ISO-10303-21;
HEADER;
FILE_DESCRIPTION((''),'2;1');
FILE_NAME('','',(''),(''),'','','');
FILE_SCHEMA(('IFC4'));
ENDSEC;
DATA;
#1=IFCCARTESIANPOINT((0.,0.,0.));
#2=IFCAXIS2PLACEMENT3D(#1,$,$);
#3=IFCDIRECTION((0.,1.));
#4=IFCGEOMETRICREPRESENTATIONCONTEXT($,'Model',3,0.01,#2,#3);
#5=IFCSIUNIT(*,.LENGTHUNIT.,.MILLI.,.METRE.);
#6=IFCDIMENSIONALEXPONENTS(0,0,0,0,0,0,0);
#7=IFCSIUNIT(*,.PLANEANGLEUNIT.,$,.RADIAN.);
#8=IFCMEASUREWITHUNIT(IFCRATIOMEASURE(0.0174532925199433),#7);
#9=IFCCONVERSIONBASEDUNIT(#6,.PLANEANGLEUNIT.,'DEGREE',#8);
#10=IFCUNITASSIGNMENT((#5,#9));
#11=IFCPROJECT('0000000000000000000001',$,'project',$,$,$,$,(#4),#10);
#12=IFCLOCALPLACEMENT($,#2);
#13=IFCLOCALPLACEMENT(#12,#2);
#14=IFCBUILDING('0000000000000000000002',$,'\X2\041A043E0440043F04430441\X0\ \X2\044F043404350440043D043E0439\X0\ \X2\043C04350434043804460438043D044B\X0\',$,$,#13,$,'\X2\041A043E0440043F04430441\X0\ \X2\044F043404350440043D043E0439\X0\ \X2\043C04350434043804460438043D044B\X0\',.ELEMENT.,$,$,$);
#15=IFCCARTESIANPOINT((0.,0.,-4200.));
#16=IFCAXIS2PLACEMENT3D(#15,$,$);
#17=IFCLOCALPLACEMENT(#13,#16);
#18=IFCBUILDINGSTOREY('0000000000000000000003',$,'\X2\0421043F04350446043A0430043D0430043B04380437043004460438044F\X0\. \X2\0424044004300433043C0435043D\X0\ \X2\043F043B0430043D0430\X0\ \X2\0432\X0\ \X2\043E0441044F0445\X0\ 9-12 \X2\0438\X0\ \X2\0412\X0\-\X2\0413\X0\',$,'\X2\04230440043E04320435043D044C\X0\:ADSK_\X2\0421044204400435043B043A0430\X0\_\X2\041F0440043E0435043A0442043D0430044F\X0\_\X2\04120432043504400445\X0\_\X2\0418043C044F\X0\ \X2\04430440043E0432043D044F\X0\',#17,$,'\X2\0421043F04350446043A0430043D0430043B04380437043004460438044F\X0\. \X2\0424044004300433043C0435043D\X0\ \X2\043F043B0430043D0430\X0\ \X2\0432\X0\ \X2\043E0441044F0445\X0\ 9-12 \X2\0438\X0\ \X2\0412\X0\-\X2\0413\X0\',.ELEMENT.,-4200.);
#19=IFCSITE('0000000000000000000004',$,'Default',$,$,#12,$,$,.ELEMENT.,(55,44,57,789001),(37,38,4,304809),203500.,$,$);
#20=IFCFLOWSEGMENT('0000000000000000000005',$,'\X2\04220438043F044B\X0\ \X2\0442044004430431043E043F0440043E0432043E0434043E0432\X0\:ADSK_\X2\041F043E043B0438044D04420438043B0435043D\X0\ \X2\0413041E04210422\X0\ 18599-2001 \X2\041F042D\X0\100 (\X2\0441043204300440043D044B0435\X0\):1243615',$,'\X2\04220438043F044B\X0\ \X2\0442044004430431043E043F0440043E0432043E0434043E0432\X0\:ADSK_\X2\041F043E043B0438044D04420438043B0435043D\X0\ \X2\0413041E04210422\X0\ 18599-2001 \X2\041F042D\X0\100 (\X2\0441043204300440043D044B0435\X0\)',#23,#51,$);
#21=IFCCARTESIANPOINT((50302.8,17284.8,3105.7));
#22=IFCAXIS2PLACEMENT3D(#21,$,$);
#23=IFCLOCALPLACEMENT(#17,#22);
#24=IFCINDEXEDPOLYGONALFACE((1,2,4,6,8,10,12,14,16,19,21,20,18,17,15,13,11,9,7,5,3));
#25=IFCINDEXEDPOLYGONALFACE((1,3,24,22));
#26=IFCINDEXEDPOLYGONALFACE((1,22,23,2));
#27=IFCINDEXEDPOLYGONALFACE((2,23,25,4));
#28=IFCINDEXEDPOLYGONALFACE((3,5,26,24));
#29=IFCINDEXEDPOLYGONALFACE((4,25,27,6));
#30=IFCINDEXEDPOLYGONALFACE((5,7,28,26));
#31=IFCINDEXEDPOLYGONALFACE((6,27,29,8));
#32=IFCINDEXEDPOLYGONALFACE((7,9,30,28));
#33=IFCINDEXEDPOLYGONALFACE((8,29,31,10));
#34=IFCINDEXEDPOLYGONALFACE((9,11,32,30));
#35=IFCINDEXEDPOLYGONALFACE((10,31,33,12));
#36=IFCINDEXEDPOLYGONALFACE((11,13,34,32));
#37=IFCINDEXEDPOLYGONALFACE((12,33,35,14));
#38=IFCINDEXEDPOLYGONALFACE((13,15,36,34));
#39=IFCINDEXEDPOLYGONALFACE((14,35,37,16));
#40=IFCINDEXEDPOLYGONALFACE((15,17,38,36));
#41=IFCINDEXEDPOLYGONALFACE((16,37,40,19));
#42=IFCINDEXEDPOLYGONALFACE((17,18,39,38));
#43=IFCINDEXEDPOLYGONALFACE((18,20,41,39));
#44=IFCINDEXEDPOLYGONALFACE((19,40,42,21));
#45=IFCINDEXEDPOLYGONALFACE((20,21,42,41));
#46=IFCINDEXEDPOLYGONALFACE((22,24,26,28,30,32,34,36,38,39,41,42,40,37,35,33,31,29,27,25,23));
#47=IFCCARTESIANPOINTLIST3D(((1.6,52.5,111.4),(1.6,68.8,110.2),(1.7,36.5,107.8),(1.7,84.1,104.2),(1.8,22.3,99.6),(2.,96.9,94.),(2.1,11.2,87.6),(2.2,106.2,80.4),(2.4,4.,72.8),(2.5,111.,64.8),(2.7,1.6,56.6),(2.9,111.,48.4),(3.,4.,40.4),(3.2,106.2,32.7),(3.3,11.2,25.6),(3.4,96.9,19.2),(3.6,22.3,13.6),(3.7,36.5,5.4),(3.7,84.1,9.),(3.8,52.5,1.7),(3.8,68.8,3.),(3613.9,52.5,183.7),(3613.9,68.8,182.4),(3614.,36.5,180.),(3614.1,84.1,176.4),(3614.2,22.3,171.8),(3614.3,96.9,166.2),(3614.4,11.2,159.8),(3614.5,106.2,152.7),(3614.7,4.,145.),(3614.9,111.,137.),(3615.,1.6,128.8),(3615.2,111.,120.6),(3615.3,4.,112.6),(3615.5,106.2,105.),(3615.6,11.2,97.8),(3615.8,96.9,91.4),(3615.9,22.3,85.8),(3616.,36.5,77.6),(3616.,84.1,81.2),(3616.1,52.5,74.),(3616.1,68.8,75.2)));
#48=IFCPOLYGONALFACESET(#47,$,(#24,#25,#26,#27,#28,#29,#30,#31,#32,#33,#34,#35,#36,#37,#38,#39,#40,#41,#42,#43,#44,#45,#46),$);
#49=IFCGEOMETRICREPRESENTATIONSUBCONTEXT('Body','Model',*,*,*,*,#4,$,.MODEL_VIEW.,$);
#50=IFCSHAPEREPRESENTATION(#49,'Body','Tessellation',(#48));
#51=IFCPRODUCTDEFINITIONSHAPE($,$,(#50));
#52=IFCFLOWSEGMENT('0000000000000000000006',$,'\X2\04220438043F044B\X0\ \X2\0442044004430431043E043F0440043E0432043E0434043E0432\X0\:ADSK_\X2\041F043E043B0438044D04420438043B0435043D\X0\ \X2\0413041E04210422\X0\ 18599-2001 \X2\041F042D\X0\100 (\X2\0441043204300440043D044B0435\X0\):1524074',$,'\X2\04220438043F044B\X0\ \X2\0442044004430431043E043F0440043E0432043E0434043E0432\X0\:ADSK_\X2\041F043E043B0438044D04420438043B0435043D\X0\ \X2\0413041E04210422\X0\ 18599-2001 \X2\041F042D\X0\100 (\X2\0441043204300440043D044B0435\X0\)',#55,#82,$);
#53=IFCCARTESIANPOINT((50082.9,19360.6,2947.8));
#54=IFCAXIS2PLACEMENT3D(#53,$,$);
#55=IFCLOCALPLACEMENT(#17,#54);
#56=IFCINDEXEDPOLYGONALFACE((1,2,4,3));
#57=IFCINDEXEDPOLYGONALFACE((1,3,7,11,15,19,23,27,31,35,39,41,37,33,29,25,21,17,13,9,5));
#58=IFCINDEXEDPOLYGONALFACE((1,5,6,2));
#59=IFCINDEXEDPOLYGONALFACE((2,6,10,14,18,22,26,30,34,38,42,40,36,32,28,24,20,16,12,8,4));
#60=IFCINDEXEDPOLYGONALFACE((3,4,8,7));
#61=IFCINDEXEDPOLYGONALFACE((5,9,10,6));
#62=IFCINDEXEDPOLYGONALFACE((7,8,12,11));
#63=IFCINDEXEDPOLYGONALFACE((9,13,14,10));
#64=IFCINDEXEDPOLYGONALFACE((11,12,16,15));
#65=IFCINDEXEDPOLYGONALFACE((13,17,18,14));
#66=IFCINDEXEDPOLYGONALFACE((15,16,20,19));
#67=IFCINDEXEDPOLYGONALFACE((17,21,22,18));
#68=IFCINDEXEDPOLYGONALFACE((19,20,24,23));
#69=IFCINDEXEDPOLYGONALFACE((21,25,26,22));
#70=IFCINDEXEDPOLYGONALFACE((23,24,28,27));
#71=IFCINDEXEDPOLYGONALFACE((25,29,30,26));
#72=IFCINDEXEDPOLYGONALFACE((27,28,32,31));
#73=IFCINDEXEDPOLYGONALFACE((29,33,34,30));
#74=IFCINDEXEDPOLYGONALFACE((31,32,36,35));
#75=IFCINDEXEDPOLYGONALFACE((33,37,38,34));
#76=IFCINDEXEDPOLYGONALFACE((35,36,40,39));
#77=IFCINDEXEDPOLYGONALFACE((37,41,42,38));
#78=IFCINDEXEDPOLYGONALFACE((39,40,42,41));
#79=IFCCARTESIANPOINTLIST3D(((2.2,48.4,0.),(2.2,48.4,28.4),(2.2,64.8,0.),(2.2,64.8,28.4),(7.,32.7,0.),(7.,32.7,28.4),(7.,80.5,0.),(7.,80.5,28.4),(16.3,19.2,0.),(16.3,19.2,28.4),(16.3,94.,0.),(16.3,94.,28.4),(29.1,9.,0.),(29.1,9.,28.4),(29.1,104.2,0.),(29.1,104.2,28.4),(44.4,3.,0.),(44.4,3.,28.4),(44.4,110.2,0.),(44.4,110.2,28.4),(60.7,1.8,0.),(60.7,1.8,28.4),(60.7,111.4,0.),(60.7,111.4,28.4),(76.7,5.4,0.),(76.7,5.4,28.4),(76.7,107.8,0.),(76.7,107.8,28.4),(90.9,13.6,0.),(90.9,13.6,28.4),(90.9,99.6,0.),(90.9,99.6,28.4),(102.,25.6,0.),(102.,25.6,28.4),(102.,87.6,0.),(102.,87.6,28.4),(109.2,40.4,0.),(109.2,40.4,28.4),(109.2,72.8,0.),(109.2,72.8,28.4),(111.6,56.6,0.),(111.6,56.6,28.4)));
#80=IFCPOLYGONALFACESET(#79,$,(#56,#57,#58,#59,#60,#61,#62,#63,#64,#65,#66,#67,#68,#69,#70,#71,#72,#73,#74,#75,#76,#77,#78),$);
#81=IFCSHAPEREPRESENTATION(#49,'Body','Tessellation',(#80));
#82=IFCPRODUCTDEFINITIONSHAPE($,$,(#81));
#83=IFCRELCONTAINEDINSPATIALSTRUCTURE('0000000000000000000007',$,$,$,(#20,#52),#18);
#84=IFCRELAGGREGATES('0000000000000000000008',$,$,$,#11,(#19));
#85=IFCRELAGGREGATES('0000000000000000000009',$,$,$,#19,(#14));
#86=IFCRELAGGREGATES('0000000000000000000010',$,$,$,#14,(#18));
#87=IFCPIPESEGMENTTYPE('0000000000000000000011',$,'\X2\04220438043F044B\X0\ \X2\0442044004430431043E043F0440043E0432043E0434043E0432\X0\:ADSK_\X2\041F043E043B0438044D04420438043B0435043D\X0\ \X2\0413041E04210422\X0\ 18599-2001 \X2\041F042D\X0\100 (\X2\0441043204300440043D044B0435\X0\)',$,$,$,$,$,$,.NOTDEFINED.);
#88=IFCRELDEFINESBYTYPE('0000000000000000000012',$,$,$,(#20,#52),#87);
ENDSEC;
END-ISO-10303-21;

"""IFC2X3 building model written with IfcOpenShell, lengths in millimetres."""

from ifc_helpers import new_model, entity, si_unit, converted_unit, direction, frame, origin, origin_2d_with_axis, place, context, subcontext, project, spatial, circle, extrude, type_object, element, save


model = new_model("IFC2X3")

# Units and contexts
model_context = context("Model", 3, precision=0.01, world=origin(), true_north=direction((0.0, 1.0)))
body_context = subcontext(model_context, "Body", "Model", "MODEL_VIEW")
ifc_project = project(units=[si_unit("LENGTHUNIT", "METRE", prefix="MILLI"), converted_unit("PLANEANGLEUNIT", "DEGREE", entity("IfcRatioMeasure", 0.0174532925199433), si_unit("PLANEANGLEUNIT", "RADIAN"), dimensions=[0, 0, 0, 0, 0, 0, 0])], contexts=[model_context])

# Site, building, storey
site_placement = place(None, origin())
site = spatial("IfcSite", under=ifc_project, at=site_placement, Name="Default", CompositionType="ELEMENT", RefLatitude=(55, 44, 57, 789001), RefLongitude=(37, 38, 4, 304809), RefElevation=203500.0)
building_placement = place(site_placement, origin())
building = spatial("IfcBuilding", under=site, at=building_placement, Name="Корпус ядерной медицины", LongName="Корпус ядерной медицины", CompositionType="ELEMENT")
storey_placement = place(building_placement, frame((0.0, 0.0, -4200.0)))
storey = spatial("IfcBuildingStorey", under=building, at=storey_placement, Name="Спецканализация. Фрагмен плана в осях 9-12 и В-Г", ObjectType="Уровень:ADSK_Стрелка_Проектная_Вверх_Имя уровня", LongName="Спецканализация. Фрагмен плана в осях 9-12 и В-Г", CompositionType="ELEMENT", Elevation=-4200.0)

# Flow segments
pipe_segment_type = type_object("IfcPipeSegmentType", Name="Типы трубопроводов:ADSK_Полиэтилен ГОСТ 18599-2001 ПЭ100 (сварные)", PredefinedType="NOTDEFINED")
flow_segment_1_placement = place(storey_placement, frame((50302.8, 17284.8, 3105.7)))
element("IfcFlowSegment", 1, at=flow_segment_1_placement, inside=storey, type_object=pipe_segment_type, Name="Типы трубопроводов:ADSK_Полиэтилен ГОСТ 18599-2001 ПЭ100 (сварные):1243615", ObjectType="Типы трубопроводов:ADSK_Полиэтилен ГОСТ 18599-2001 ПЭ100 (сварные)", context=body_context, shape_type="SweptSolid", body=[
    extrude(circle(Radius=55.0, at=origin_2d_with_axis()), frame((2.7, 56.6, 56.6), z_axis=(0.9998, 0.0, 0.019996), x_axis=(0.0, -1.0, 0.0)), (0.0, 0.0, 1.0), 3613.0),
])
flow_segment_2_placement = place(storey_placement, frame((50082.9, 19360.6, 2947.8)))
element("IfcFlowSegment", 2, at=flow_segment_2_placement, inside=storey, type_object=pipe_segment_type, Name="Типы трубопроводов:ADSK_Полиэтилен ГОСТ 18599-2001 ПЭ100 (сварные):1524074", ObjectType="Типы трубопроводов:ADSK_Полиэтилен ГОСТ 18599-2001 ПЭ100 (сварные)", context=body_context, shape_type="SweptSolid", body=[
    extrude(circle(Radius=55.0, at=origin_2d_with_axis()), frame((56.6, 56.6, 0.0)), (0.0, 0.0, 1.0), 28.4),
])

save(model, "model.ifc")
